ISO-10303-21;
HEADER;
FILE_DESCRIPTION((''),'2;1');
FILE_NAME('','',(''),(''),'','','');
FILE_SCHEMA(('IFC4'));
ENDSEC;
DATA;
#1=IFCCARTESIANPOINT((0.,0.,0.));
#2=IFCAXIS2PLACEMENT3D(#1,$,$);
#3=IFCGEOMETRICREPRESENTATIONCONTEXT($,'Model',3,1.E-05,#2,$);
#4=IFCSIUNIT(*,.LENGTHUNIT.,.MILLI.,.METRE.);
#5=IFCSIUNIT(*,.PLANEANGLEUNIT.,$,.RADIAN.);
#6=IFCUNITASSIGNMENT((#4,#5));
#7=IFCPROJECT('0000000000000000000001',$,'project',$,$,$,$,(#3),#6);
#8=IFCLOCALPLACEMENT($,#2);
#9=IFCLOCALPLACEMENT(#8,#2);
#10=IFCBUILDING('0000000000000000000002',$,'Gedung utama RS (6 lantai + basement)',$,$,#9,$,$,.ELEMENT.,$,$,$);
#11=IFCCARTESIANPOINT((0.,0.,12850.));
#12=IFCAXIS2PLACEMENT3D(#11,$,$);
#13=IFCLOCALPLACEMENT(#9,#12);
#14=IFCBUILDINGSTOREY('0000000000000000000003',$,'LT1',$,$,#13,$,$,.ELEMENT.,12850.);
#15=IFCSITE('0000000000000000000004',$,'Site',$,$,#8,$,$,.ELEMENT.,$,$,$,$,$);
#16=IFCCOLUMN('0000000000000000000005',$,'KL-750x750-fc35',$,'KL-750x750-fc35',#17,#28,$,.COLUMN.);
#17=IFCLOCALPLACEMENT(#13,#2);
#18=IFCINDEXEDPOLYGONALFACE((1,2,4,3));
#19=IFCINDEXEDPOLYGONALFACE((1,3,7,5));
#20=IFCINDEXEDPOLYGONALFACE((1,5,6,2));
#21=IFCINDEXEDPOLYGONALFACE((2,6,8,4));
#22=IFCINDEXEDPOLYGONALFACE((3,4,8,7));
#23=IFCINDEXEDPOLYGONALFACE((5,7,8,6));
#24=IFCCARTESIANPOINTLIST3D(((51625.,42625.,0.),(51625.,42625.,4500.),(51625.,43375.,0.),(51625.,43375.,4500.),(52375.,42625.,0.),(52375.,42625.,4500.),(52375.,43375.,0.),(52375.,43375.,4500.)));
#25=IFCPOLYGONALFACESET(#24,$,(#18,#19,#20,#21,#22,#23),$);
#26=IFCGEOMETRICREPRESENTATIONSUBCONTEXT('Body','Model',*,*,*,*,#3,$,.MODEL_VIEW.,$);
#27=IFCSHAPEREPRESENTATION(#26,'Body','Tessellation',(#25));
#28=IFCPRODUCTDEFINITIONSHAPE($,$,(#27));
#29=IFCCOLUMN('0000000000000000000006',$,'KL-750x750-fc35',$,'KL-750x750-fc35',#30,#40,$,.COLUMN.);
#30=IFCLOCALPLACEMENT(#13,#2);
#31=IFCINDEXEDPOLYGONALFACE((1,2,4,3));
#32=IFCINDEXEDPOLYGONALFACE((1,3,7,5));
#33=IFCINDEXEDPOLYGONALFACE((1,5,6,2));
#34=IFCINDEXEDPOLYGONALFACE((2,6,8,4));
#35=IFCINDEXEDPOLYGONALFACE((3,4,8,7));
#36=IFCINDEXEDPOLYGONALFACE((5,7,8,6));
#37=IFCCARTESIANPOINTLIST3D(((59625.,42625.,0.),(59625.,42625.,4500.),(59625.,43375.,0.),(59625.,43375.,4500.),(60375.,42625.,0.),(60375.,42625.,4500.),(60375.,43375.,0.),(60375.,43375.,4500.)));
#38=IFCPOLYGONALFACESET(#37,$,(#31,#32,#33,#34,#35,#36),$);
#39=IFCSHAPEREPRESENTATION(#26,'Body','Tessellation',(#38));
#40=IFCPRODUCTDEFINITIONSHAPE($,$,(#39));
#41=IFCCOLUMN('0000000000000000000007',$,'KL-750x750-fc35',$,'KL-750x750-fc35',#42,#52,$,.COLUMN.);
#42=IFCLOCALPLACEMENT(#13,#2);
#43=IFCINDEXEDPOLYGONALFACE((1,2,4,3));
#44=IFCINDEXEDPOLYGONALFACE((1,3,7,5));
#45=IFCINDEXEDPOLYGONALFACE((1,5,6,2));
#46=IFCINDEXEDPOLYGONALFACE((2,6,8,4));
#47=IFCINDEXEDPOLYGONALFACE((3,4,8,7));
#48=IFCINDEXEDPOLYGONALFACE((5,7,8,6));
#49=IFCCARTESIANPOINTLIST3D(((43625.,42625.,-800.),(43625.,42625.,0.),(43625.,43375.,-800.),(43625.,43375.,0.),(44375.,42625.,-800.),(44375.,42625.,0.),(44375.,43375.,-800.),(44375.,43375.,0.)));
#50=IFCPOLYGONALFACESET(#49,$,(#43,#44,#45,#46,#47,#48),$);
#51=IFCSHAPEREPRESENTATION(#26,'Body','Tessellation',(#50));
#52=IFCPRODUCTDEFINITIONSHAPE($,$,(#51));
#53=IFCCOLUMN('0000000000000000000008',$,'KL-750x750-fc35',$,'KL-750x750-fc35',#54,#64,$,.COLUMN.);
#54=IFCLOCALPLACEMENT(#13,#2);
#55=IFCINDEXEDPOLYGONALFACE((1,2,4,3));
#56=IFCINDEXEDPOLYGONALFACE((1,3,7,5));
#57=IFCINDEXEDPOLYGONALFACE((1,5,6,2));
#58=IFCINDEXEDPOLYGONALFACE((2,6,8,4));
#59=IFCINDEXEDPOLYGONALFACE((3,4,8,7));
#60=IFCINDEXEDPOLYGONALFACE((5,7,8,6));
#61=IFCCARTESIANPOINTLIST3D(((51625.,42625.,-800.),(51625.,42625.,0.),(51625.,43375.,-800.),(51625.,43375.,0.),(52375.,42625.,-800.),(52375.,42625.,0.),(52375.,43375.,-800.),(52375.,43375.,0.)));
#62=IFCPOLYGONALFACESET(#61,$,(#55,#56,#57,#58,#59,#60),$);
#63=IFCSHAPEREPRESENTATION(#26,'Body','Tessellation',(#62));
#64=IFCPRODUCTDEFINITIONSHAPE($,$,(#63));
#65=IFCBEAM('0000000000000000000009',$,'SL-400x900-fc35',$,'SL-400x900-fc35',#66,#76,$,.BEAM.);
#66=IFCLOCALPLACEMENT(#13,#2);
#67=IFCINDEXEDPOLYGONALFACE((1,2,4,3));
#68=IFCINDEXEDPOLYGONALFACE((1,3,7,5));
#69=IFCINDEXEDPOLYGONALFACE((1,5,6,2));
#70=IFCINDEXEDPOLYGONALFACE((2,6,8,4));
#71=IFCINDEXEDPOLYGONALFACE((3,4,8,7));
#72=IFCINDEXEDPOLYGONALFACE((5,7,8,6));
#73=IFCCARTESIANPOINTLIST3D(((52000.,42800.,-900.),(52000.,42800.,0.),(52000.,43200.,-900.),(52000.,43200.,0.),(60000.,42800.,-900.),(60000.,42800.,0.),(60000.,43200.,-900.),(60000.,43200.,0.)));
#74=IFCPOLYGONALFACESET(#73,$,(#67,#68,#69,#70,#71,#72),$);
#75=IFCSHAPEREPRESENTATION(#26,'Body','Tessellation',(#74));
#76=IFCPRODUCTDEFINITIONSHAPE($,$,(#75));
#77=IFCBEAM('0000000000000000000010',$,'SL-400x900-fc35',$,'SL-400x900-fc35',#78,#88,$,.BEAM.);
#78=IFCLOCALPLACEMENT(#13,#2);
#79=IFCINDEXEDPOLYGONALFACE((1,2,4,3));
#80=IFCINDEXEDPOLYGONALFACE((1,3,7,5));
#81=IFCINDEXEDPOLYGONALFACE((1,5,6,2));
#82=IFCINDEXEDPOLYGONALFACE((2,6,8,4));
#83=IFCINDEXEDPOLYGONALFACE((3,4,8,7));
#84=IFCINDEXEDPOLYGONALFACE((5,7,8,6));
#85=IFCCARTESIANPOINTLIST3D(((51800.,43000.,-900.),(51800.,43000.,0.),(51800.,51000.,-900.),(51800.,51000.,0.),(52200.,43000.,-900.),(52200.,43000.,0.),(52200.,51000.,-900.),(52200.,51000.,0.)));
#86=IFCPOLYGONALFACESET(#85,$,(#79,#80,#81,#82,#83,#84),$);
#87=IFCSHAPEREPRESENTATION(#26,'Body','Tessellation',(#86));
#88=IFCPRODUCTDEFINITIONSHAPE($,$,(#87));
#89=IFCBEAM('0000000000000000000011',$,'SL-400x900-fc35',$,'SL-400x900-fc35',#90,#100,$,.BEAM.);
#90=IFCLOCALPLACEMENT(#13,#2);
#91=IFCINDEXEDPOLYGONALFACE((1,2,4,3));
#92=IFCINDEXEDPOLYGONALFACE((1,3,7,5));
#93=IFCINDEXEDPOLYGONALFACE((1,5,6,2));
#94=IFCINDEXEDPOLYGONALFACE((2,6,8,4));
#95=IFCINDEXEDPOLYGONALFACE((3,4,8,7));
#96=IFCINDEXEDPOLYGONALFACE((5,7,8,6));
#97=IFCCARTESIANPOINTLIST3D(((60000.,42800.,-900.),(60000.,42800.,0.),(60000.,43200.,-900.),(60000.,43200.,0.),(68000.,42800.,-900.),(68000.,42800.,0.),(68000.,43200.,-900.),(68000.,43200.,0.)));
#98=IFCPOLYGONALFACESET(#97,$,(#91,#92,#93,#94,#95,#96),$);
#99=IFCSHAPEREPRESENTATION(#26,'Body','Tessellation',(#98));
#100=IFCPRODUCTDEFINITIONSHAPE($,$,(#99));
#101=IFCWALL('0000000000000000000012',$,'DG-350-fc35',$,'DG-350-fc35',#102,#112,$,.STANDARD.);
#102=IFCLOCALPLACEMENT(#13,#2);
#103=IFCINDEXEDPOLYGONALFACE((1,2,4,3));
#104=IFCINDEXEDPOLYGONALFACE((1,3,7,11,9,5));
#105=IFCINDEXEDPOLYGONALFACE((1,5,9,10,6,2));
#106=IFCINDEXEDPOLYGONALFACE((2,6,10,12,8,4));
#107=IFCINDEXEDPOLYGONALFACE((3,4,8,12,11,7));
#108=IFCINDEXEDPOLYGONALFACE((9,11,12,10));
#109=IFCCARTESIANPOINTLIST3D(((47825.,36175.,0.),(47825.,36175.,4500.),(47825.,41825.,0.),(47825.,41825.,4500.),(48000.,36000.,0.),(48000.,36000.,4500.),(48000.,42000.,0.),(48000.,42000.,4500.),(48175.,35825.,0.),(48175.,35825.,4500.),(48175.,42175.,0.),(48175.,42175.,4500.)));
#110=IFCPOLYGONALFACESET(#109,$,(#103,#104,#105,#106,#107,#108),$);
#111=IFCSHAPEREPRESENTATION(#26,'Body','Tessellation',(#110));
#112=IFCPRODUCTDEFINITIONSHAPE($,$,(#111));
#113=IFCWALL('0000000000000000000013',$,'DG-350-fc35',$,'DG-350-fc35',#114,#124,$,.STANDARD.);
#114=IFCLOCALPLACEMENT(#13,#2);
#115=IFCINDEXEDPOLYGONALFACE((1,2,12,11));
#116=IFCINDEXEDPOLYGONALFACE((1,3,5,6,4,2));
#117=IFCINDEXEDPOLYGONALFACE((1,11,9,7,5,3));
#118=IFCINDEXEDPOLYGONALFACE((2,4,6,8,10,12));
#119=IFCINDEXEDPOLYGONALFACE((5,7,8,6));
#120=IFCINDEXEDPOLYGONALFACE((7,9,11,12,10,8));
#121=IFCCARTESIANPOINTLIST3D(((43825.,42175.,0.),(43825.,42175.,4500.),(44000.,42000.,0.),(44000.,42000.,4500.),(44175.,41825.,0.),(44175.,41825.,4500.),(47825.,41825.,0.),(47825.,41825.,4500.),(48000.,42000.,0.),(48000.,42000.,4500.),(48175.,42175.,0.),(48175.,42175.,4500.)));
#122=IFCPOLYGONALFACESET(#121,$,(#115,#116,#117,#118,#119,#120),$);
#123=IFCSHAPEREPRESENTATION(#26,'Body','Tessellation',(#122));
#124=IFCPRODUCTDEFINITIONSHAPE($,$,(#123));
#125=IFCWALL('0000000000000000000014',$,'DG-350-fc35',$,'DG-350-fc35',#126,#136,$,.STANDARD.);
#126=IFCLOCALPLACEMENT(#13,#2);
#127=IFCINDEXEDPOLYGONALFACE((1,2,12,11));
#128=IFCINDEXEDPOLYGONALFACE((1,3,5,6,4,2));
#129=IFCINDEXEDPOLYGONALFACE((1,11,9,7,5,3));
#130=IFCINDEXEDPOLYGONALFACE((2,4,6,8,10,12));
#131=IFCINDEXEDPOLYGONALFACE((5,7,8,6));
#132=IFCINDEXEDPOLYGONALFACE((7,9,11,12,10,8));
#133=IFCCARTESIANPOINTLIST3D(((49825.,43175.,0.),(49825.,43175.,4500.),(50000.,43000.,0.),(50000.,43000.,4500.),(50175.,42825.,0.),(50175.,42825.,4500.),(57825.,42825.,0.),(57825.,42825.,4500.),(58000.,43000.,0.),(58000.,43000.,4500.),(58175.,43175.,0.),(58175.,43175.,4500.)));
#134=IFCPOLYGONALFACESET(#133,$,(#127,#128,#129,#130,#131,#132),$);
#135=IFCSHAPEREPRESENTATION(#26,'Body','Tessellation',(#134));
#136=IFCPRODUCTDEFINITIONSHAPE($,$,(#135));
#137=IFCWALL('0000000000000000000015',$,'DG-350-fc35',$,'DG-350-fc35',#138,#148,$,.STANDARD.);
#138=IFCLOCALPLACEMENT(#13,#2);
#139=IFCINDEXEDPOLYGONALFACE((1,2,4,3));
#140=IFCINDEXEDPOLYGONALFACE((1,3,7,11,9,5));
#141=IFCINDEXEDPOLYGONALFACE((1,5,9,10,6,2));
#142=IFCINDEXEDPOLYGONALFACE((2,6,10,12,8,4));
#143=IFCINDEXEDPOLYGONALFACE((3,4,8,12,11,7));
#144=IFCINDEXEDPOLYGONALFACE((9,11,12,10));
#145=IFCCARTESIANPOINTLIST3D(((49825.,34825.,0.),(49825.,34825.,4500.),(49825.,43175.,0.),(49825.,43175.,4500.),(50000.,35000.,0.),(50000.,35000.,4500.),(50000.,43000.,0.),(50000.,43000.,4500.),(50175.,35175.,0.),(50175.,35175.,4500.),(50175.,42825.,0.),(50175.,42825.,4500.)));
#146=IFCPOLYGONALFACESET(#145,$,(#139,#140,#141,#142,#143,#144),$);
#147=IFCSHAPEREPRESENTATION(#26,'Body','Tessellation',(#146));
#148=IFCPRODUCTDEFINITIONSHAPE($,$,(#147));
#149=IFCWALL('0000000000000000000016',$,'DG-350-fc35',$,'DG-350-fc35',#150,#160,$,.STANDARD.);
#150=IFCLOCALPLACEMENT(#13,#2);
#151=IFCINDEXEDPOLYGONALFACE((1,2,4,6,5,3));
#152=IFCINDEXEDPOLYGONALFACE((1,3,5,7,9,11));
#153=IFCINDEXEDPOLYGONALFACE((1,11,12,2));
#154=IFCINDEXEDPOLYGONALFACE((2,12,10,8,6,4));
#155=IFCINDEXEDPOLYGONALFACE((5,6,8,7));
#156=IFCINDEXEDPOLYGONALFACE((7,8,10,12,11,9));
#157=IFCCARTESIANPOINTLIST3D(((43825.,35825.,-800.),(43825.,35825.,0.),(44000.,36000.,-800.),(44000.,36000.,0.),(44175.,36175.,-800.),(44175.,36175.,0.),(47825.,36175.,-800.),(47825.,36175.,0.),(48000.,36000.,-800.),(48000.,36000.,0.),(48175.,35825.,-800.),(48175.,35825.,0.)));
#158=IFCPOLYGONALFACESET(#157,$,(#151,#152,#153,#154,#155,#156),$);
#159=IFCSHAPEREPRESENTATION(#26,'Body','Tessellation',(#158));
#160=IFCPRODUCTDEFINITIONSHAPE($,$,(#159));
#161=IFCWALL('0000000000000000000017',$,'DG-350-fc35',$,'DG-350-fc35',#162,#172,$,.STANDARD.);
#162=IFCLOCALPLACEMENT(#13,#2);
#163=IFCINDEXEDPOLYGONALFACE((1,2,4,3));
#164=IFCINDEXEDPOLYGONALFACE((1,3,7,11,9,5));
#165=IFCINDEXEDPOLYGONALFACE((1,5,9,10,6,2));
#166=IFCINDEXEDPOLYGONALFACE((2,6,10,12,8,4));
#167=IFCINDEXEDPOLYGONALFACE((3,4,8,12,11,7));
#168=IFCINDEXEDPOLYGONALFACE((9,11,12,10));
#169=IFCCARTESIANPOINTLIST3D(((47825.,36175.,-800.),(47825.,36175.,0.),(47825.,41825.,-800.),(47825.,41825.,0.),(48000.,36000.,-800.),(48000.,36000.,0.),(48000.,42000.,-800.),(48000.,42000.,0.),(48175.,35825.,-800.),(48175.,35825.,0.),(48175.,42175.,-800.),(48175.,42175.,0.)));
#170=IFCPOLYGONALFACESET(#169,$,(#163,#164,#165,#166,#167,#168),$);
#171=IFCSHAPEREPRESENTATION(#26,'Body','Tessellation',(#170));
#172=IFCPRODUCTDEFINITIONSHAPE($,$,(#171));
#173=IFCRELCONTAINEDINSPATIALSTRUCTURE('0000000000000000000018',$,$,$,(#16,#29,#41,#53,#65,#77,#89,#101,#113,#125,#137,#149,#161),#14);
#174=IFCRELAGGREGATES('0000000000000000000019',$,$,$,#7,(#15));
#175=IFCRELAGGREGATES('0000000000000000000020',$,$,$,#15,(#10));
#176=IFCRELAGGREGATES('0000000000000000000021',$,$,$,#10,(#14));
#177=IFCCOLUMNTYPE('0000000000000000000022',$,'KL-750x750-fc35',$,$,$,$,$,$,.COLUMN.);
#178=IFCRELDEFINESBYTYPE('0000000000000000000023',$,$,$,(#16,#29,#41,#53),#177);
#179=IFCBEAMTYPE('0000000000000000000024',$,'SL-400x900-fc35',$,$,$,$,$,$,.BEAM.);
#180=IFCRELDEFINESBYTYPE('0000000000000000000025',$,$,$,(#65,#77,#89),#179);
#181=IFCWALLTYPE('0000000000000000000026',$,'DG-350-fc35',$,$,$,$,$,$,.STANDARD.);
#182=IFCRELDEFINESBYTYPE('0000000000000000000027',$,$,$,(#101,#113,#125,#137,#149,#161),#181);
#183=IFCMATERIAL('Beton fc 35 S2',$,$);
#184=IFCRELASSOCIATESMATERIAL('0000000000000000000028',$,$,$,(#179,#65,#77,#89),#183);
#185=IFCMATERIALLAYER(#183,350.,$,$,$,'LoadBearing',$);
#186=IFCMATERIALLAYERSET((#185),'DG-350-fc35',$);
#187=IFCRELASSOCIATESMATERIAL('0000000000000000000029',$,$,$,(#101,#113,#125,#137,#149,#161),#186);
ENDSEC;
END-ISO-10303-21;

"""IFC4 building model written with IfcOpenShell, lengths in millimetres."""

from ifc_helpers import new_model, si_unit, frame, origin, origin_2d, place, context, subcontext, project, spatial, polyline, rectangle, outline, extrude, material, layer, layer_set, layer_usage, material_profile, profile_set, profile_usage, type_object, element, save


model = new_model("IFC4")

# Units and contexts
model_context = context("Model", 3, precision=1e-05, world=origin())
body_context = subcontext(model_context, "Body", "Model", "MODEL_VIEW")
ifc_project = project(units=[si_unit("LENGTHUNIT", "METRE", prefix="MILLI"), si_unit("PLANEANGLEUNIT", "RADIAN")], contexts=[model_context])

# Site, building, storey
site_placement = place(None, origin())
site = spatial("IfcSite", under=ifc_project, at=site_placement, Name="Site", CompositionType="ELEMENT")
building_placement = place(site_placement, origin())
building = spatial("IfcBuilding", under=site, at=building_placement, Name="Gedung utama RS (6 lantai + basement)", CompositionType="ELEMENT")
storey_placement = place(building_placement, frame((0.0, 0.0, 12850.0)))
storey = spatial("IfcBuildingStorey", under=building, at=storey_placement, Name="LT1", CompositionType="ELEMENT", Elevation=12850.0)

# Columns
ifc_material_profile_1 = material_profile(None, rectangle(XDim=750.0, YDim=750.0, at=origin_2d()), Name="KL-750x750-fc35")
ifc_profile_set_1 = profile_set([ifc_material_profile_1], Name="KL-750x750-fc35")
ifc_profile_usage_1 = profile_usage(ifc_profile_set_1, cardinal=5)
column_type = type_object("IfcColumnType", Name="KL-750x750-fc35", PredefinedType="COLUMN", material=ifc_profile_set_1)
for number, where, z_axis, x_axis, name in (
    (1, (52000.0, 43000.0, 0.0), (0.0, 0.0, 1.0), (1.0, 0.0, 0.0), "KL-750x750-fc35"),
    (2, (60000.0, 43000.0, 0.0), (0.0, 0.0, 1.0), (1.0, 0.0, 0.0), "KL-750x750-fc35"),
):
    element("IfcColumn", number, at=place(storey_placement, frame(where, z_axis=z_axis, x_axis=x_axis)), inside=storey, type_object=column_type, material=ifc_profile_usage_1, Name=name, ObjectType="KL-750x750-fc35", PredefinedType="COLUMN", context=body_context, shape_type="SweptSolid", body=[
        extrude(rectangle(XDim=750.0, YDim=750.0, at=origin_2d()), origin(), (0.0, 0.0, 1.0), 4500.0),
    ])
for number, where, z_axis, x_axis, name in (
    (3, (44000.0, 43000.0, -800.0), (0.0, 0.0, 1.0), (1.0, 0.0, 0.0), "KL-750x750-fc35"),
    (4, (52000.0, 43000.0, -800.0), (0.0, 0.0, 1.0), (1.0, 0.0, 0.0), "KL-750x750-fc35"),
):
    element("IfcColumn", number, at=place(storey_placement, frame(where, z_axis=z_axis, x_axis=x_axis)), inside=storey, type_object=column_type, material=ifc_profile_usage_1, Name=name, ObjectType="KL-750x750-fc35", PredefinedType="COLUMN", context=body_context, shape_type="SweptSolid", body=[
        extrude(rectangle(XDim=750.0, YDim=750.0, at=origin_2d()), origin(), (0.0, 0.0, 1.0), 800.0),
    ])

# Beams
ifc_material = material(Name="Beton fc 35 S2")
ifc_material_profile_2 = material_profile(ifc_material, rectangle(XDim=400.0, YDim=900.0, at=origin_2d()), Name="SL-400x900-fc35")
ifc_profile_set_2 = profile_set([ifc_material_profile_2], Name="SL-400x900-fc35")
ifc_profile_usage_2 = profile_usage(ifc_profile_set_2, cardinal=8)
beam_type = type_object("IfcBeamType", Name="SL-400x900-fc35", PredefinedType="BEAM", material=ifc_profile_set_2)
beam_1_placement = place(storey_placement, frame((52000.0, 43000.0, -450.0)))
element("IfcBeam", 5, at=beam_1_placement, inside=storey, type_object=beam_type, material=ifc_profile_usage_2, Name="SL-400x900-fc35", ObjectType="SL-400x900-fc35", PredefinedType="BEAM", context=body_context, shape_type="SweptSolid", body=[
    extrude(rectangle(XDim=400.0, YDim=900.0, at=origin_2d()), frame((0.0, 0.0, 0.0), z_axis=(1.0, 0.0, 0.0), x_axis=(0.0, 1.0, 0.0)), (0.0, 0.0, 1.0), 8000.0),
])
beam_2_placement = place(storey_placement, frame((52000.0, 43000.0, -450.0)))
element("IfcBeam", 6, at=beam_2_placement, inside=storey, type_object=beam_type, material=ifc_profile_usage_2, Name="SL-400x900-fc35", ObjectType="SL-400x900-fc35", PredefinedType="BEAM", context=body_context, shape_type="SweptSolid", body=[
    extrude(rectangle(XDim=400.0, YDim=900.0, at=origin_2d()), frame((0.0, 0.0, 0.0), z_axis=(0.0, 1.0, 0.0), x_axis=(-1.0, 0.0, 0.0)), (0.0, 0.0, 1.0), 8000.0),
])
beam_3_placement = place(storey_placement, frame((60000.0, 43000.0, -450.0)))
element("IfcBeam", 7, at=beam_3_placement, inside=storey, type_object=beam_type, material=ifc_profile_usage_2, Name="SL-400x900-fc35", ObjectType="SL-400x900-fc35", PredefinedType="BEAM", context=body_context, shape_type="SweptSolid", body=[
    extrude(rectangle(XDim=400.0, YDim=900.0, at=origin_2d()), frame((0.0, 0.0, 0.0), z_axis=(1.0, 0.0, 0.0), x_axis=(0.0, 1.0, 0.0)), (0.0, 0.0, 1.0), 8000.0),
])

# Walls
ifc_layer_1 = layer(ifc_material, 350.0, Category="LoadBearing")
ifc_layer_set_1 = layer_set([ifc_layer_1], Name="DG-350-fc35")
ifc_layer_usage_1 = layer_usage(ifc_layer_set_1, "AXIS2", "NEGATIVE", 175.0)
wall_type_1 = type_object("IfcWallType", Name="DG-350-fc35", PredefinedType="STANDARD")
wall_1_placement = place(storey_placement, frame((48000.0, 36000.0, 0.0), z_axis=(0.0, 0.0, 1.0), x_axis=(0.0, 1.0, 0.0)))
element("IfcWall", 8, at=wall_1_placement, inside=storey, type_object=wall_type_1, material=ifc_layer_usage_1, Name="DG-350-fc35", ObjectType="DG-350-fc35", PredefinedType="STANDARD", context=body_context, shape_type="SweptSolid", body=[
    extrude(outline(polyline([(-175.0, -175.0), (0.0, 0.0), (175.0, 175.0), (5825.0, 175.0), (6000.0, 0.0), (6175.0, -175.0), (-175.0, -175.0)])), origin(), (0.0, 0.0, 1.0), 4500.0),
])
wall_2_placement = place(storey_placement, frame((48000.0, 42000.0, 0.0), z_axis=(0.0, 0.0, 1.0), x_axis=(-1.0, 0.0, 0.0)))
element("IfcWall", 9, at=wall_2_placement, inside=storey, type_object=wall_type_1, material=ifc_layer_usage_1, Name="DG-350-fc35", ObjectType="DG-350-fc35", PredefinedType="STANDARD", context=body_context, shape_type="SweptSolid", body=[
    extrude(outline(polyline([(-175.0, -175.0), (0.0, 0.0), (175.0, 175.0), (3825.0, 175.0), (4000.0, 0.0), (4175.0, -175.0), (-175.0, -175.0)])), origin(), (0.0, 0.0, 1.0), 4500.0),
])
for number, where, z_axis, x_axis, name in (
    (10, (58000.0, 43000.0, 0.0), (0.0, 0.0, 1.0), (-1.0, 0.0, 0.0), "DG-350-fc35"),
    (11, (50000.0, 43000.0, 0.0), (0.0, 0.0, 1.0), (0.0, -1.0, 0.0), "DG-350-fc35"),
):
    element("IfcWall", number, at=place(storey_placement, frame(where, z_axis=z_axis, x_axis=x_axis)), inside=storey, type_object=wall_type_1, material=ifc_layer_usage_1, Name=name, ObjectType="DG-350-fc35", PredefinedType="STANDARD", context=body_context, shape_type="SweptSolid", body=[
        extrude(outline(polyline([(-175.0, -175.0), (0.0, 0.0), (175.0, 175.0), (7825.0, 175.0), (8000.0, 0.0), (8175.0, -175.0), (-175.0, -175.0)])), origin(), (0.0, 0.0, 1.0), 4500.0),
    ])
wall_3_placement = place(storey_placement, frame((44000.0, 36000.0, -800.0), z_axis=(0.0, 0.0, 1.0), x_axis=(1.0, 0.0, 0.0)))
element("IfcWall", 12, at=wall_3_placement, inside=storey, type_object=wall_type_1, material=ifc_layer_usage_1, Name="DG-350-fc35", ObjectType="DG-350-fc35", PredefinedType="STANDARD", context=body_context, shape_type="SweptSolid", body=[
    extrude(outline(polyline([(-175.0, -175.0), (0.0, 0.0), (175.0, 175.0), (3825.0, 175.0), (4000.0, 0.0), (4175.0, -175.0), (-175.0, -175.0)])), origin(), (0.0, 0.0, 1.0), 800.0),
])
wall_4_placement = place(storey_placement, frame((48000.0, 36000.0, -800.0), z_axis=(0.0, 0.0, 1.0), x_axis=(0.0, 1.0, 0.0)))
element("IfcWall", 13, at=wall_4_placement, inside=storey, type_object=wall_type_1, material=ifc_layer_usage_1, Name="DG-350-fc35", ObjectType="DG-350-fc35", PredefinedType="STANDARD", context=body_context, shape_type="SweptSolid", body=[
    extrude(outline(polyline([(-175.0, -175.0), (0.0, 0.0), (175.0, 175.0), (5825.0, 175.0), (6000.0, 0.0), (6175.0, -175.0), (-175.0, -175.0)])), origin(), (0.0, 0.0, 1.0), 800.0),
])

save(model, "model.ifc")
